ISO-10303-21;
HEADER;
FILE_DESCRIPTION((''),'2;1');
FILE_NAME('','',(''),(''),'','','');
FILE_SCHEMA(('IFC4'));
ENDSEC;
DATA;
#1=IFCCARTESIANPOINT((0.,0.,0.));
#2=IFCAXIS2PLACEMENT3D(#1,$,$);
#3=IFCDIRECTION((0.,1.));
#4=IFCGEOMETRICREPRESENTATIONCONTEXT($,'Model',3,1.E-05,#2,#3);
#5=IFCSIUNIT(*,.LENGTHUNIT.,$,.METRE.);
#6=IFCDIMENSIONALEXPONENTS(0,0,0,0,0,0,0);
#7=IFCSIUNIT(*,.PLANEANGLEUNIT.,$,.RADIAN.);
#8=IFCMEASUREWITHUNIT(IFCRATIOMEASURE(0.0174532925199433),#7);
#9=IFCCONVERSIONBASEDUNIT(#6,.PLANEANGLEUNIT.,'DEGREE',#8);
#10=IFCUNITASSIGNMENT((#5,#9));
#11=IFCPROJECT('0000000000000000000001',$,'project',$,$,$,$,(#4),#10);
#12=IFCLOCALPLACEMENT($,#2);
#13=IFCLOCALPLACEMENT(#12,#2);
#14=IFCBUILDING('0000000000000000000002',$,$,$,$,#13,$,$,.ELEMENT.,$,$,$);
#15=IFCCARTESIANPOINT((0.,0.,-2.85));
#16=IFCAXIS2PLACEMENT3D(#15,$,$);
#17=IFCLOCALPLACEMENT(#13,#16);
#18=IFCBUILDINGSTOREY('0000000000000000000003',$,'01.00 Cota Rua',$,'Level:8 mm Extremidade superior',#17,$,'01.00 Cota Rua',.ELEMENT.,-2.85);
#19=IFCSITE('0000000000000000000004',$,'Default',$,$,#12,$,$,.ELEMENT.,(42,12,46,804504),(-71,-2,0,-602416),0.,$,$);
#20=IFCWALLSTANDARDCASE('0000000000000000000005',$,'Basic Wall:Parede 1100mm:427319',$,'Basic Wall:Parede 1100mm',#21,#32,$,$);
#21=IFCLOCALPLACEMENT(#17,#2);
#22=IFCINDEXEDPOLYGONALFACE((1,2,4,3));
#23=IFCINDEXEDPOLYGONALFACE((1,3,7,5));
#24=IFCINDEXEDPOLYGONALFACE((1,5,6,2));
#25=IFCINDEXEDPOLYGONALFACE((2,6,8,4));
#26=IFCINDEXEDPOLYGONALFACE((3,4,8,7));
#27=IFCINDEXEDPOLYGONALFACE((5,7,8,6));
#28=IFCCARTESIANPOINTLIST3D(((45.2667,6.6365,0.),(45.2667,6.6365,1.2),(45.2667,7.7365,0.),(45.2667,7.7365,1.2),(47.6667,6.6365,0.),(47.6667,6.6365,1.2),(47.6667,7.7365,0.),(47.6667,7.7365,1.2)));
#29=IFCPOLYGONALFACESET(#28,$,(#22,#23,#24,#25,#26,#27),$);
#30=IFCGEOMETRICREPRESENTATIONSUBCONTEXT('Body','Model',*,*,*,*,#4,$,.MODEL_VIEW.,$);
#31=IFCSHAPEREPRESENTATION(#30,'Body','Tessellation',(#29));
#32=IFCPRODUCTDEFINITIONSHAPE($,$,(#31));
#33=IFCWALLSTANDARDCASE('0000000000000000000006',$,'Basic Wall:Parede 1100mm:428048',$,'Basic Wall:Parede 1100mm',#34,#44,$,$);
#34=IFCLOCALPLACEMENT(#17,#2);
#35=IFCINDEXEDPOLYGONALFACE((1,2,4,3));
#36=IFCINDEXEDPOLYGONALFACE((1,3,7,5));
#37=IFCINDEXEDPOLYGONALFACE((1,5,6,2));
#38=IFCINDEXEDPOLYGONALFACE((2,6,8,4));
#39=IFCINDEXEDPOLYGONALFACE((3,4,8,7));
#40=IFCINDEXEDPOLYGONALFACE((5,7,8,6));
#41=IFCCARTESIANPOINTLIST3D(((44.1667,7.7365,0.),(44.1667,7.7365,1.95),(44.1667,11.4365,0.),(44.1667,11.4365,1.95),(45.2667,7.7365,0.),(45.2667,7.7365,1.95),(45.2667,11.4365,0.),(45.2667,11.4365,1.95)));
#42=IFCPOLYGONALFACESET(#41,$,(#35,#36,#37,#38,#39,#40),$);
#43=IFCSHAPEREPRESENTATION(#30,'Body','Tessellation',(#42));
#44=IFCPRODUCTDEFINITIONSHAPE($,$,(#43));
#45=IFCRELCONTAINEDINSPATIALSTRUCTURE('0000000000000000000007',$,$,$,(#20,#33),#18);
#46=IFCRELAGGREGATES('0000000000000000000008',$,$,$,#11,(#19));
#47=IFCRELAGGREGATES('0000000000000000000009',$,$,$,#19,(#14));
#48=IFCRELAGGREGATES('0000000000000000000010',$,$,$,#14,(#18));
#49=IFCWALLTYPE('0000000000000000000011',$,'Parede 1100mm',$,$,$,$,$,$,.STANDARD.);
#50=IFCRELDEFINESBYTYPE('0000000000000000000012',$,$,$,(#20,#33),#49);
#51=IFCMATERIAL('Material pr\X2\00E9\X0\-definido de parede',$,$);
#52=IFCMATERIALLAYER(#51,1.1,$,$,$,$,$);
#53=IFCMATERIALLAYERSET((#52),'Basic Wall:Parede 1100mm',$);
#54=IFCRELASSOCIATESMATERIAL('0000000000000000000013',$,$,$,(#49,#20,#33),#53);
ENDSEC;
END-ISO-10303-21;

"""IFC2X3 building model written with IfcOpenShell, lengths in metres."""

from ifc_helpers import new_model, entity, si_unit, converted_unit, direction, frame, frame_2d, origin, place, context, subcontext, project, spatial, rectangle, extrude, clip, halfspace, material, layer, layer_set, layer_usage, type_object, element, save


model = new_model("IFC2X3")

# Units and contexts
model_context = context("Model", 3, precision=1e-05, world=origin(), true_north=direction((0.0, 1.0)))
body_context = subcontext(model_context, "Body", "Model", "MODEL_VIEW")
ifc_project = project(units=[si_unit("LENGTHUNIT", "METRE"), converted_unit("PLANEANGLEUNIT", "DEGREE", entity("IfcRatioMeasure", 0.0174532925199433), si_unit("PLANEANGLEUNIT", "RADIAN"), dimensions=[0, 0, 0, 0, 0, 0, 0])], contexts=[model_context])

# Site, building, storey
site_placement = place(None, origin())
site = spatial("IfcSite", under=ifc_project, at=site_placement, Name="Default", CompositionType="ELEMENT", RefLatitude=(42, 12, 46, 804504), RefLongitude=(-71, -2, 0, -602416), RefElevation=0.0)
building_placement = place(site_placement, origin())
building = spatial("IfcBuilding", under=site, at=building_placement, CompositionType="ELEMENT")
storey_placement = place(building_placement, frame((0.0, 0.0, -2.85)))
storey = spatial("IfcBuildingStorey", under=building, at=storey_placement, Name="01.00 Cota Rua", ObjectType="Level:8 mm Extremidade superior", LongName="01.00 Cota Rua", CompositionType="ELEMENT", Elevation=-2.85)

# Walls
ifc_material = material(Name="Material pré-definido de parede")
ifc_layer_1 = layer(ifc_material, 1.1)
ifc_layer_set_1 = layer_set([ifc_layer_1], Name="Basic Wall:Parede 1100mm")
wall_type_1 = type_object("IfcWallType", Name="Parede 1100mm", PredefinedType="STANDARD", material=ifc_layer_set_1)
ifc_layer_usage_1 = layer_usage(ifc_layer_set_1, "AXIS2", "POSITIVE", -0.55)
wall_1_placement = place(storey_placement, frame((47.6667, 7.1865, 0.0), z_axis=(0.0, 0.0, 1.0), x_axis=(-1.0, 0.0, 0.0)))
element("IfcWallStandardCase", 1, at=wall_1_placement, inside=storey, type_object=wall_type_1, material=ifc_layer_usage_1, Name="Basic Wall:Parede 1100mm:427319", ObjectType="Basic Wall:Parede 1100mm", context=body_context, shape_type="SweptSolid", body=[
    extrude(rectangle(XDim=2.4, YDim=1.1, at=frame_2d((1.2, 0.0), x_axis=(-1.0, 0.0))), origin(), (0.0, 0.0, 1.0), 1.2),
])
ifc_layer_usage_2 = layer_usage(ifc_layer_set_1, "AXIS2", "POSITIVE", -0.55)
wall_2_placement = place(storey_placement, frame((44.7167, 7.7365, 0.0), z_axis=(0.0, 0.0, 1.0), x_axis=(0.0, 1.0, 0.0)))
element("IfcWallStandardCase", 2, at=wall_2_placement, inside=storey, type_object=wall_type_1, material=ifc_layer_usage_2, Name="Basic Wall:Parede 1100mm:428048", ObjectType="Basic Wall:Parede 1100mm", context=body_context, shape_type="Clipping", body=[
    clip(extrude(rectangle(XDim=3.7, YDim=1.1, at=frame_2d((1.85, 0.0), x_axis=(-1.0, 0.0))), origin(), (0.0, 0.0, 1.0), 1.95), halfspace(origin(), True)),
])

save(model, "model.ifc")
